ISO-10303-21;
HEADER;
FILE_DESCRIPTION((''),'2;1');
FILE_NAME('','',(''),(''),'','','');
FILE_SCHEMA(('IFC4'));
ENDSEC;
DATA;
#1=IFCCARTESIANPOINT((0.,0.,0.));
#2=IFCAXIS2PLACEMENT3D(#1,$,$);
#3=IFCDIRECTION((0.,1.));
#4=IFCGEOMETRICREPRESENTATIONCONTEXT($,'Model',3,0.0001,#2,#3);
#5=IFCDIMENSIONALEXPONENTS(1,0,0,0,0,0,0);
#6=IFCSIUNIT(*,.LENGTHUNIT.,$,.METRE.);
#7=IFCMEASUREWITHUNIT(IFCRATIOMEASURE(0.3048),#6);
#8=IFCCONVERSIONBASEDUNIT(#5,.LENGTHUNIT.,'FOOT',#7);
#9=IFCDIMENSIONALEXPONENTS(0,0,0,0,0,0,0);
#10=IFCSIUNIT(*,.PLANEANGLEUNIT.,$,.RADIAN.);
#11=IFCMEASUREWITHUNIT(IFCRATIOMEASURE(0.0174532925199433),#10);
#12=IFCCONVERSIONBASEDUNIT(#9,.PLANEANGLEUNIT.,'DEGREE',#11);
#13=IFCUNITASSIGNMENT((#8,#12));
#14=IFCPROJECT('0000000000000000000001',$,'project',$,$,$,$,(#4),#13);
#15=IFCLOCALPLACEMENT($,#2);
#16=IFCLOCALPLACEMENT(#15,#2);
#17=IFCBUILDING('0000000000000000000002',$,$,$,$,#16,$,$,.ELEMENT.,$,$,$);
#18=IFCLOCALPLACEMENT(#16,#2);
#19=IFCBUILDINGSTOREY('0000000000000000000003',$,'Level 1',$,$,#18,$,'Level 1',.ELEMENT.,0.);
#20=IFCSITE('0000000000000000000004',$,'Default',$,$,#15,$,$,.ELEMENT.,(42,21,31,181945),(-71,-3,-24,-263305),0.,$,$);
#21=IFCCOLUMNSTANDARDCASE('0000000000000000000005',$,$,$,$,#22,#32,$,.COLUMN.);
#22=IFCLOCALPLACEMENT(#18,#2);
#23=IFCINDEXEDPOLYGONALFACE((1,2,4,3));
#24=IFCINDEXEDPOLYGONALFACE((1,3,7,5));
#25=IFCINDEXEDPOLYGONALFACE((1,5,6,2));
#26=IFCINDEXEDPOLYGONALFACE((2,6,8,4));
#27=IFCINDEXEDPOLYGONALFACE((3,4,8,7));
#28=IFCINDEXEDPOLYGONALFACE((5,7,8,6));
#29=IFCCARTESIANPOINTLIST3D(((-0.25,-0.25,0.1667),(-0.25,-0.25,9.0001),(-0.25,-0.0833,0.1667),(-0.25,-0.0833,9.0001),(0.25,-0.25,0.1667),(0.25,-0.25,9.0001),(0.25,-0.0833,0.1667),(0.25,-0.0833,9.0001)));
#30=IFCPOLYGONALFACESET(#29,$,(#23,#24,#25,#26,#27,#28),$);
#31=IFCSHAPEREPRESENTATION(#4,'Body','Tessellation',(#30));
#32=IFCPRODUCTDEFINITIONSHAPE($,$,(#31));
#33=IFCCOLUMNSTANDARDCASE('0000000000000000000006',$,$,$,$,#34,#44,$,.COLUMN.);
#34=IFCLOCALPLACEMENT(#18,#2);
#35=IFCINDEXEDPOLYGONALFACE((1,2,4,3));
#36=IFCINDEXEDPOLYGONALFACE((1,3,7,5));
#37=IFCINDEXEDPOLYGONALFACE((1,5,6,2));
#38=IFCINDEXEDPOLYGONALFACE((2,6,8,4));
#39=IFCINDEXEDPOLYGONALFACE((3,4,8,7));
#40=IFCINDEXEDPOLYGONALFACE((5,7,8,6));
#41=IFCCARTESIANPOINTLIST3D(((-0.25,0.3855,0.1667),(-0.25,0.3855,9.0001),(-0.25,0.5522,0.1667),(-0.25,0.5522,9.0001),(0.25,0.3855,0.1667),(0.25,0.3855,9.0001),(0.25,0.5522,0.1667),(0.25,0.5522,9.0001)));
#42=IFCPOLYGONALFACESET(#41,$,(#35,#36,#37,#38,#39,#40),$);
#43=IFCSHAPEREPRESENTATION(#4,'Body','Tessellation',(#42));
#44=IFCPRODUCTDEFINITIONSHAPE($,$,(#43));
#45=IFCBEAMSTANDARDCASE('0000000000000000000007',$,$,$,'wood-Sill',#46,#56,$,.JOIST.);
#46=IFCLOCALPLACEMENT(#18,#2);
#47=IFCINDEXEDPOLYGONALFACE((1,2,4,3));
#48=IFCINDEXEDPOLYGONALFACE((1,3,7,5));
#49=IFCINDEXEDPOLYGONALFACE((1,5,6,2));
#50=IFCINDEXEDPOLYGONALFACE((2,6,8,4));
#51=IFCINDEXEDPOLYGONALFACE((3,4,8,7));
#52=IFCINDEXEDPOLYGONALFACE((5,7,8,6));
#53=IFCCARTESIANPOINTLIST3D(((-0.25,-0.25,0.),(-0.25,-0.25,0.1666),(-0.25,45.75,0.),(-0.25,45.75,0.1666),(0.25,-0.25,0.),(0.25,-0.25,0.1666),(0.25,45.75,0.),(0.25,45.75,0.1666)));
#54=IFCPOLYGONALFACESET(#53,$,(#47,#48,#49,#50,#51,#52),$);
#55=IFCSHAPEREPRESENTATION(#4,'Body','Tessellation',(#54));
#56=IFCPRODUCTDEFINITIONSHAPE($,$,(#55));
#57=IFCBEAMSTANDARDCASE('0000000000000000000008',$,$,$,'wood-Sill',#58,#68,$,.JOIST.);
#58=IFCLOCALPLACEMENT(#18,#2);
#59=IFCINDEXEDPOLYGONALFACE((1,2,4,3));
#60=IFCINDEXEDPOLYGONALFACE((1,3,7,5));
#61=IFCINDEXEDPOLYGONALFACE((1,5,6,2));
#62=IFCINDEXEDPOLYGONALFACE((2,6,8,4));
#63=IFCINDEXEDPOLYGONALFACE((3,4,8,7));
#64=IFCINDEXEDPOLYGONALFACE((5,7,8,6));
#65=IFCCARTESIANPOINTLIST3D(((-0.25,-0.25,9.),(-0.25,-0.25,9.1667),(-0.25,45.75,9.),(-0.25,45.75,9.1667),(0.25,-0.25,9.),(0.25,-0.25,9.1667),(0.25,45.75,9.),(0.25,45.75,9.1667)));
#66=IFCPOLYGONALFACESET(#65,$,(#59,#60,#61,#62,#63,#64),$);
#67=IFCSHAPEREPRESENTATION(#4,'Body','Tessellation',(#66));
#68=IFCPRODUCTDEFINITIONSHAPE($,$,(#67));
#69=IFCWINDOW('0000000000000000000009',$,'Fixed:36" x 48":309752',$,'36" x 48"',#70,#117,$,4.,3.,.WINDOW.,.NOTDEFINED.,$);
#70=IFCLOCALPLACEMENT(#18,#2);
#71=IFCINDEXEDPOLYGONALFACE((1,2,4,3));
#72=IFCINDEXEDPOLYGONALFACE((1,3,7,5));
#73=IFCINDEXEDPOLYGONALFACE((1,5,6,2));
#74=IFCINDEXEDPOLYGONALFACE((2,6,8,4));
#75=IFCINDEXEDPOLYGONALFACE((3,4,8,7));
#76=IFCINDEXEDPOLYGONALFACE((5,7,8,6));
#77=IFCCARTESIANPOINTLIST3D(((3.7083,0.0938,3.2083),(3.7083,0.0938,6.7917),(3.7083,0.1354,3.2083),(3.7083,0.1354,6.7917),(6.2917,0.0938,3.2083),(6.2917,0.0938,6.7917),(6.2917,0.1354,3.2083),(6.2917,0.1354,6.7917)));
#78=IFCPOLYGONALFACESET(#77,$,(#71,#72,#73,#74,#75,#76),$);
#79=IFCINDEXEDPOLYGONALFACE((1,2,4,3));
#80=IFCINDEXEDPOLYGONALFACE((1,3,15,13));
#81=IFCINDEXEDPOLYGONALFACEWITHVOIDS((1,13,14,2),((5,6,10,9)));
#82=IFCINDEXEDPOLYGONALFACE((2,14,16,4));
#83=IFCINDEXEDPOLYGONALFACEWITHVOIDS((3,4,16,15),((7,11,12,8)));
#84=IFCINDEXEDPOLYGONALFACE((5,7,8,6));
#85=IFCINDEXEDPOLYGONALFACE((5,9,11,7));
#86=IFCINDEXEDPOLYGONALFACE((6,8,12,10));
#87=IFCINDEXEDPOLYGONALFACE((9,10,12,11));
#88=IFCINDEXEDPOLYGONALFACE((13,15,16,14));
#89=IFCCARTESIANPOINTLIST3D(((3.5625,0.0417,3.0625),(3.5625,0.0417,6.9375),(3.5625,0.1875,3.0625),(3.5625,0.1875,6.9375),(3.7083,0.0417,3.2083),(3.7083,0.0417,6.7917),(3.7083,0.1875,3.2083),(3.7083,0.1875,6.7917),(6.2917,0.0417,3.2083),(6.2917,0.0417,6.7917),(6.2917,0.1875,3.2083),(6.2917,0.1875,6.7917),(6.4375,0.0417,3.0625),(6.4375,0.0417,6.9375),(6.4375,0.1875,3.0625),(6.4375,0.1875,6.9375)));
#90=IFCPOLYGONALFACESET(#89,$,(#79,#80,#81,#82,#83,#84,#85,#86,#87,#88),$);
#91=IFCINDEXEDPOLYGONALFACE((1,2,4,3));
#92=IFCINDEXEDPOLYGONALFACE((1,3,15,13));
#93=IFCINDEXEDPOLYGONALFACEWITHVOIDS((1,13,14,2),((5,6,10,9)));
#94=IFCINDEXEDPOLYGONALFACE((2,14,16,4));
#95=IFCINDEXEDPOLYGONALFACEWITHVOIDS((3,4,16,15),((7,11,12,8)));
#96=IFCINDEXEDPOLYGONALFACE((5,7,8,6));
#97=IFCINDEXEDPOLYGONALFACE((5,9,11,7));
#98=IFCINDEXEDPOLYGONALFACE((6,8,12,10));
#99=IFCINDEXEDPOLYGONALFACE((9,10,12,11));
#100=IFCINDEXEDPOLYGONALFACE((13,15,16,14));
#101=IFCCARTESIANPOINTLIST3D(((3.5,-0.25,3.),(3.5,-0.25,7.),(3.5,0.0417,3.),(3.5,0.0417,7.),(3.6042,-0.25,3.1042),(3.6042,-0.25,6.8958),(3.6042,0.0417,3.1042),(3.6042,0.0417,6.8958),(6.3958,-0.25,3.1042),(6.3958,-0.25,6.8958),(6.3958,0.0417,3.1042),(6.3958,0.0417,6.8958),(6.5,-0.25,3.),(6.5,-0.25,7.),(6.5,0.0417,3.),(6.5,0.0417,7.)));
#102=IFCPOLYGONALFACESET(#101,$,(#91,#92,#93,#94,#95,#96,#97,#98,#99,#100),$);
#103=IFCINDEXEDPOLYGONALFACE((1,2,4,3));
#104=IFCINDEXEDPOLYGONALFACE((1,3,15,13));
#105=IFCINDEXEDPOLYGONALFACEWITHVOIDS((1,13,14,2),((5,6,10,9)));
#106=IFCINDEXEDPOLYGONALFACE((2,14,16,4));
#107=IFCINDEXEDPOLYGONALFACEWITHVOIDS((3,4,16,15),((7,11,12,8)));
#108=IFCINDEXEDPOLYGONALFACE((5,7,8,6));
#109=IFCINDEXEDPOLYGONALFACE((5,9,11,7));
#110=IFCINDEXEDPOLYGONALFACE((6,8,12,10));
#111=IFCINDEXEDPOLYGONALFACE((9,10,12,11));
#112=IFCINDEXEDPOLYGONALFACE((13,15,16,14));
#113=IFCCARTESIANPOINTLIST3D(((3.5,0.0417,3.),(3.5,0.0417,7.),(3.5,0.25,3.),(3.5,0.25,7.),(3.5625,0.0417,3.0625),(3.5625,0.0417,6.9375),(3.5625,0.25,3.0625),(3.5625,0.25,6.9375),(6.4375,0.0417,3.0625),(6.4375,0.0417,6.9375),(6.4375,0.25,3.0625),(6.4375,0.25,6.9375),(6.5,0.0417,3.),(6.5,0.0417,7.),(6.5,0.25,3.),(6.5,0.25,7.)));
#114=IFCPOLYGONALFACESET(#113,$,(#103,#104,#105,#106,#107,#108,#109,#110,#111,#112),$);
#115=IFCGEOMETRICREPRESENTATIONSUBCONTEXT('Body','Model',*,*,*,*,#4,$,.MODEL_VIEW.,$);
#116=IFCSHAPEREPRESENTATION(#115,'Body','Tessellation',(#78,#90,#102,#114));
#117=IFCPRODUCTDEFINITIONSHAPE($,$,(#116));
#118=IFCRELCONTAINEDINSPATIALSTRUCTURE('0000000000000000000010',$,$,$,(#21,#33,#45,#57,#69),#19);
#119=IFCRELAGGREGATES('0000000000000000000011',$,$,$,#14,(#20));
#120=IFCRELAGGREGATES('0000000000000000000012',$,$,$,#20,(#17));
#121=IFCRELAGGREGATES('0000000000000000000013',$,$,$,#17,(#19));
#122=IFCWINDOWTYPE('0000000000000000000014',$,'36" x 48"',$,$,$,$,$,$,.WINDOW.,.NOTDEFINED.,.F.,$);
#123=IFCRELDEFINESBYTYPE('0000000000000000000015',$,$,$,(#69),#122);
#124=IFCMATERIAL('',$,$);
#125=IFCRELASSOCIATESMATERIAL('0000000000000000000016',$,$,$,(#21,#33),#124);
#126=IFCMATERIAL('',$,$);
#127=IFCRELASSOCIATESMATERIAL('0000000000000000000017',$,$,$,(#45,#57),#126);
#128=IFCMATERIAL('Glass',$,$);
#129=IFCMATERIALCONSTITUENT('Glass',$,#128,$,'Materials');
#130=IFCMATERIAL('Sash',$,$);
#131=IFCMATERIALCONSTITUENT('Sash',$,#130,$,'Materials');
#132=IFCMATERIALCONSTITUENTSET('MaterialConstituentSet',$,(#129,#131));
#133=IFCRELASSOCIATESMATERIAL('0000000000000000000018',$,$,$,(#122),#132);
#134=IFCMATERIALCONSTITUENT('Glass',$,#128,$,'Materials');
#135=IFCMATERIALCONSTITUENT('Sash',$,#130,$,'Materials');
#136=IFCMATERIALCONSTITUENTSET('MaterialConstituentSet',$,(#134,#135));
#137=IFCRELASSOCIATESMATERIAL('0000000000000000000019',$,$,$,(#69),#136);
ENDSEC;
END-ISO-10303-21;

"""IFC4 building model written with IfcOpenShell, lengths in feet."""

from ifc_helpers import new_model, entity, si_unit, converted_unit, direction, frame, frame_2d, origin, origin_with_axes, place, context, subcontext, project, spatial, polyline, rectangle, outline, extrude, source, transform, mapped, material, constituent, constituent_set, type_object, type_shapes, element, save


model = new_model("IFC4")

# Units and contexts
model_context = context("Model", 3, precision=0.0001, world=origin(), true_north=direction((0.0, 1.0)))
body_context = subcontext(model_context, "Body", "Model", "MODEL_VIEW")
ifc_project = project(units=[converted_unit("LENGTHUNIT", "FOOT", entity("IfcRatioMeasure", 0.3048), si_unit("LENGTHUNIT", "METRE"), dimensions=[1, 0, 0, 0, 0, 0, 0]), converted_unit("PLANEANGLEUNIT", "DEGREE", entity("IfcRatioMeasure", 0.0174532925199433), si_unit("PLANEANGLEUNIT", "RADIAN"), dimensions=[0, 0, 0, 0, 0, 0, 0])], contexts=[model_context])

# Site, building, storey
site_placement = place(None, origin())
site = spatial("IfcSite", under=ifc_project, at=site_placement, Name="Default", CompositionType="ELEMENT", RefLatitude=(42, 21, 31, 181945), RefLongitude=(-71, -3, -24, -263305), RefElevation=0.0)
building_placement = place(site_placement, origin())
building = spatial("IfcBuilding", under=site, at=building_placement, CompositionType="ELEMENT")
storey_placement = place(building_placement, origin())
storey = spatial("IfcBuildingStorey", under=building, at=storey_placement, Name="Level 1", LongName="Level 1", CompositionType="ELEMENT", Elevation=0.0)

# Columns
ifc_material_1 = material(Name="")
placement_1 = place(storey_placement, frame((0.0, -0.25, 0.0), z_axis=(0.0, 0.0, 1.0), x_axis=(0.0, 1.0, 0.0)))
for number, where, z_axis, x_axis in (
    (1, (0.0833, 0.0, 0.1667), (0.0, 0.0, 1.0), (1.0, 0.0, 0.0)),
    (2, (0.7188, 0.0, 0.1667), (0.0, 0.0, 1.0), (1.0, 0.0, 0.0)),
):
    element("IfcColumnStandardCase", number, at=place(placement_1, frame(where, z_axis=z_axis, x_axis=x_axis)), inside=storey, material=ifc_material_1, PredefinedType="COLUMN", context=model_context, shape_type="SweptSolid", body=[
        extrude(rectangle(XDim=0.1667, YDim=0.5), origin(), (0.0, 0.0, 1.0), 8.8334),
    ])
placement_2 = place(storey_placement, frame((46.25, 0.0, 0.0), z_axis=(0.0, 0.0, 1.0), x_axis=(-1.0, 0.0, 0.0)))

# Beams
ifc_material_2 = material(Name="")
for number, where, z_axis, x_axis in (
    (3, (0.0, 0.0, 0.0833), (1.0, 0.0, 0.0), (0.0, 0.0, 1.0)),
    (4, (0.0, 0.0, 9.0834), (1.0, 0.0, 0.0), (0.0, 0.0, 1.0)),
):
    element("IfcBeamStandardCase", number, at=place(placement_1, frame(where, z_axis=z_axis, x_axis=x_axis)), inside=storey, material=ifc_material_2, ObjectType="wood-Sill", PredefinedType="JOIST", context=model_context, shape_type="SweptSolid", body=[
        extrude(rectangle(XDim=0.1667, YDim=0.5), origin_with_axes(), (0.0, 0.0, 1.0), 46.0),
    ])

# Window
ifc_material_3 = material(Name="Glass")
ifc_constituent_1 = constituent(ifc_material_3, Name="Glass", Category="Materials")
ifc_material_4 = material(Name="Sash")
ifc_constituent_2 = constituent(ifc_material_4, Name="Sash", Category="Materials")
ifc_constituent_set_1 = constituent_set(constituents=[ifc_constituent_1, ifc_constituent_2], Name="MaterialConstituentSet")
ifc_constituent_3 = constituent(ifc_material_3, Name="Glass", Category="Materials")
ifc_constituent_4 = constituent(ifc_material_4, Name="Sash", Category="Materials")
ifc_constituent_set_2 = constituent_set(constituents=[ifc_constituent_3, ifc_constituent_4], Name="MaterialConstituentSet")
window_type = type_object("IfcWindowType", Name="36\" x 48\"", ParameterTakesPrecedence=False, PartitioningType="NOTDEFINED", PredefinedType="WINDOW", material=ifc_constituent_set_2)
shared_shape = source(origin(), body_context, "Body", "SweptSolid", [
    extrude(rectangle(XDim=0.0417, YDim=2.5833, at=frame_2d((0.0, 0.0), x_axis=(1.0, 0.0))), frame((1.5, 0.3646, 0.2083), z_axis=(0.0, 0.0, 1.0), x_axis=(0.0, 1.0, 0.0)), (0.0, 0.0, 1.0), 3.5833),
    extrude(outline(polyline([(-1.4375, -1.9375), (1.4375, -1.9375), (1.4375, 1.9375), (-1.4375, 1.9375), (-1.4375, -1.9375)]), holes=[polyline([(-1.2917, -1.7917), (-1.2917, 1.7917), (1.2917, 1.7917), (1.2917, -1.7917), (-1.2917, -1.7917)])]), frame((1.5, 0.2917, 2.0), z_axis=(0.0, 1.0, 0.0), x_axis=(1.0, 0.0, 0.0)), (0.0, 0.0, 1.0), 0.1458),
    extrude(outline(polyline([(-1.5, -2.0), (1.5, -2.0), (1.5, 2.0), (-1.5, 2.0), (-1.5, -2.0)]), holes=[polyline([(-1.3958, -1.8958), (-1.3958, 1.8958), (1.3958, 1.8958), (1.3958, -1.8958), (-1.3958, -1.8958)])]), frame((1.5, 0.0, 2.0), z_axis=(0.0, 1.0, 0.0), x_axis=(1.0, 0.0, 0.0)), (0.0, 0.0, 1.0), 0.2917),
    extrude(outline(polyline([(-2.0, -1.5), (2.0, -1.5), (2.0, 1.5), (-2.0, 1.5), (-2.0, -1.5)]), holes=[polyline([(-1.9375, -1.4375), (-1.9375, 1.4375), (1.9375, 1.4375), (1.9375, -1.4375), (-1.9375, -1.4375)])]), frame((1.5, 0.2917, 2.0), z_axis=(0.0, 1.0, 0.0), x_axis=(0.0, 0.0, -1.0)), (0.0, 0.0, 1.0), 0.2083),
])
type_shapes(window_type, [shared_shape])
placement_3 = place(placement_2, frame((42.75, 0.25, 3.0)))
window_placement = place(placement_3, frame((0.0, 0.0, 0.0), z_axis=(0.0, 0.0, 1.0), x_axis=(-1.0, 0.0, 0.0)))
element("IfcWindow", 5, at=window_placement, inside=storey, type_object=window_type, material=ifc_constituent_set_1, Name="Fixed:36\" x 48\":309752", ObjectType="36\" x 48\"", OverallHeight=4.0, OverallWidth=3.0, PartitioningType="NOTDEFINED", PredefinedType="WINDOW", context=body_context, shape_type="MappedRepresentation", body=[
    mapped(shared_shape, transform((0.0, 0.0, 0.0), scale=1.0)),
])

save(model, "model.ifc")
